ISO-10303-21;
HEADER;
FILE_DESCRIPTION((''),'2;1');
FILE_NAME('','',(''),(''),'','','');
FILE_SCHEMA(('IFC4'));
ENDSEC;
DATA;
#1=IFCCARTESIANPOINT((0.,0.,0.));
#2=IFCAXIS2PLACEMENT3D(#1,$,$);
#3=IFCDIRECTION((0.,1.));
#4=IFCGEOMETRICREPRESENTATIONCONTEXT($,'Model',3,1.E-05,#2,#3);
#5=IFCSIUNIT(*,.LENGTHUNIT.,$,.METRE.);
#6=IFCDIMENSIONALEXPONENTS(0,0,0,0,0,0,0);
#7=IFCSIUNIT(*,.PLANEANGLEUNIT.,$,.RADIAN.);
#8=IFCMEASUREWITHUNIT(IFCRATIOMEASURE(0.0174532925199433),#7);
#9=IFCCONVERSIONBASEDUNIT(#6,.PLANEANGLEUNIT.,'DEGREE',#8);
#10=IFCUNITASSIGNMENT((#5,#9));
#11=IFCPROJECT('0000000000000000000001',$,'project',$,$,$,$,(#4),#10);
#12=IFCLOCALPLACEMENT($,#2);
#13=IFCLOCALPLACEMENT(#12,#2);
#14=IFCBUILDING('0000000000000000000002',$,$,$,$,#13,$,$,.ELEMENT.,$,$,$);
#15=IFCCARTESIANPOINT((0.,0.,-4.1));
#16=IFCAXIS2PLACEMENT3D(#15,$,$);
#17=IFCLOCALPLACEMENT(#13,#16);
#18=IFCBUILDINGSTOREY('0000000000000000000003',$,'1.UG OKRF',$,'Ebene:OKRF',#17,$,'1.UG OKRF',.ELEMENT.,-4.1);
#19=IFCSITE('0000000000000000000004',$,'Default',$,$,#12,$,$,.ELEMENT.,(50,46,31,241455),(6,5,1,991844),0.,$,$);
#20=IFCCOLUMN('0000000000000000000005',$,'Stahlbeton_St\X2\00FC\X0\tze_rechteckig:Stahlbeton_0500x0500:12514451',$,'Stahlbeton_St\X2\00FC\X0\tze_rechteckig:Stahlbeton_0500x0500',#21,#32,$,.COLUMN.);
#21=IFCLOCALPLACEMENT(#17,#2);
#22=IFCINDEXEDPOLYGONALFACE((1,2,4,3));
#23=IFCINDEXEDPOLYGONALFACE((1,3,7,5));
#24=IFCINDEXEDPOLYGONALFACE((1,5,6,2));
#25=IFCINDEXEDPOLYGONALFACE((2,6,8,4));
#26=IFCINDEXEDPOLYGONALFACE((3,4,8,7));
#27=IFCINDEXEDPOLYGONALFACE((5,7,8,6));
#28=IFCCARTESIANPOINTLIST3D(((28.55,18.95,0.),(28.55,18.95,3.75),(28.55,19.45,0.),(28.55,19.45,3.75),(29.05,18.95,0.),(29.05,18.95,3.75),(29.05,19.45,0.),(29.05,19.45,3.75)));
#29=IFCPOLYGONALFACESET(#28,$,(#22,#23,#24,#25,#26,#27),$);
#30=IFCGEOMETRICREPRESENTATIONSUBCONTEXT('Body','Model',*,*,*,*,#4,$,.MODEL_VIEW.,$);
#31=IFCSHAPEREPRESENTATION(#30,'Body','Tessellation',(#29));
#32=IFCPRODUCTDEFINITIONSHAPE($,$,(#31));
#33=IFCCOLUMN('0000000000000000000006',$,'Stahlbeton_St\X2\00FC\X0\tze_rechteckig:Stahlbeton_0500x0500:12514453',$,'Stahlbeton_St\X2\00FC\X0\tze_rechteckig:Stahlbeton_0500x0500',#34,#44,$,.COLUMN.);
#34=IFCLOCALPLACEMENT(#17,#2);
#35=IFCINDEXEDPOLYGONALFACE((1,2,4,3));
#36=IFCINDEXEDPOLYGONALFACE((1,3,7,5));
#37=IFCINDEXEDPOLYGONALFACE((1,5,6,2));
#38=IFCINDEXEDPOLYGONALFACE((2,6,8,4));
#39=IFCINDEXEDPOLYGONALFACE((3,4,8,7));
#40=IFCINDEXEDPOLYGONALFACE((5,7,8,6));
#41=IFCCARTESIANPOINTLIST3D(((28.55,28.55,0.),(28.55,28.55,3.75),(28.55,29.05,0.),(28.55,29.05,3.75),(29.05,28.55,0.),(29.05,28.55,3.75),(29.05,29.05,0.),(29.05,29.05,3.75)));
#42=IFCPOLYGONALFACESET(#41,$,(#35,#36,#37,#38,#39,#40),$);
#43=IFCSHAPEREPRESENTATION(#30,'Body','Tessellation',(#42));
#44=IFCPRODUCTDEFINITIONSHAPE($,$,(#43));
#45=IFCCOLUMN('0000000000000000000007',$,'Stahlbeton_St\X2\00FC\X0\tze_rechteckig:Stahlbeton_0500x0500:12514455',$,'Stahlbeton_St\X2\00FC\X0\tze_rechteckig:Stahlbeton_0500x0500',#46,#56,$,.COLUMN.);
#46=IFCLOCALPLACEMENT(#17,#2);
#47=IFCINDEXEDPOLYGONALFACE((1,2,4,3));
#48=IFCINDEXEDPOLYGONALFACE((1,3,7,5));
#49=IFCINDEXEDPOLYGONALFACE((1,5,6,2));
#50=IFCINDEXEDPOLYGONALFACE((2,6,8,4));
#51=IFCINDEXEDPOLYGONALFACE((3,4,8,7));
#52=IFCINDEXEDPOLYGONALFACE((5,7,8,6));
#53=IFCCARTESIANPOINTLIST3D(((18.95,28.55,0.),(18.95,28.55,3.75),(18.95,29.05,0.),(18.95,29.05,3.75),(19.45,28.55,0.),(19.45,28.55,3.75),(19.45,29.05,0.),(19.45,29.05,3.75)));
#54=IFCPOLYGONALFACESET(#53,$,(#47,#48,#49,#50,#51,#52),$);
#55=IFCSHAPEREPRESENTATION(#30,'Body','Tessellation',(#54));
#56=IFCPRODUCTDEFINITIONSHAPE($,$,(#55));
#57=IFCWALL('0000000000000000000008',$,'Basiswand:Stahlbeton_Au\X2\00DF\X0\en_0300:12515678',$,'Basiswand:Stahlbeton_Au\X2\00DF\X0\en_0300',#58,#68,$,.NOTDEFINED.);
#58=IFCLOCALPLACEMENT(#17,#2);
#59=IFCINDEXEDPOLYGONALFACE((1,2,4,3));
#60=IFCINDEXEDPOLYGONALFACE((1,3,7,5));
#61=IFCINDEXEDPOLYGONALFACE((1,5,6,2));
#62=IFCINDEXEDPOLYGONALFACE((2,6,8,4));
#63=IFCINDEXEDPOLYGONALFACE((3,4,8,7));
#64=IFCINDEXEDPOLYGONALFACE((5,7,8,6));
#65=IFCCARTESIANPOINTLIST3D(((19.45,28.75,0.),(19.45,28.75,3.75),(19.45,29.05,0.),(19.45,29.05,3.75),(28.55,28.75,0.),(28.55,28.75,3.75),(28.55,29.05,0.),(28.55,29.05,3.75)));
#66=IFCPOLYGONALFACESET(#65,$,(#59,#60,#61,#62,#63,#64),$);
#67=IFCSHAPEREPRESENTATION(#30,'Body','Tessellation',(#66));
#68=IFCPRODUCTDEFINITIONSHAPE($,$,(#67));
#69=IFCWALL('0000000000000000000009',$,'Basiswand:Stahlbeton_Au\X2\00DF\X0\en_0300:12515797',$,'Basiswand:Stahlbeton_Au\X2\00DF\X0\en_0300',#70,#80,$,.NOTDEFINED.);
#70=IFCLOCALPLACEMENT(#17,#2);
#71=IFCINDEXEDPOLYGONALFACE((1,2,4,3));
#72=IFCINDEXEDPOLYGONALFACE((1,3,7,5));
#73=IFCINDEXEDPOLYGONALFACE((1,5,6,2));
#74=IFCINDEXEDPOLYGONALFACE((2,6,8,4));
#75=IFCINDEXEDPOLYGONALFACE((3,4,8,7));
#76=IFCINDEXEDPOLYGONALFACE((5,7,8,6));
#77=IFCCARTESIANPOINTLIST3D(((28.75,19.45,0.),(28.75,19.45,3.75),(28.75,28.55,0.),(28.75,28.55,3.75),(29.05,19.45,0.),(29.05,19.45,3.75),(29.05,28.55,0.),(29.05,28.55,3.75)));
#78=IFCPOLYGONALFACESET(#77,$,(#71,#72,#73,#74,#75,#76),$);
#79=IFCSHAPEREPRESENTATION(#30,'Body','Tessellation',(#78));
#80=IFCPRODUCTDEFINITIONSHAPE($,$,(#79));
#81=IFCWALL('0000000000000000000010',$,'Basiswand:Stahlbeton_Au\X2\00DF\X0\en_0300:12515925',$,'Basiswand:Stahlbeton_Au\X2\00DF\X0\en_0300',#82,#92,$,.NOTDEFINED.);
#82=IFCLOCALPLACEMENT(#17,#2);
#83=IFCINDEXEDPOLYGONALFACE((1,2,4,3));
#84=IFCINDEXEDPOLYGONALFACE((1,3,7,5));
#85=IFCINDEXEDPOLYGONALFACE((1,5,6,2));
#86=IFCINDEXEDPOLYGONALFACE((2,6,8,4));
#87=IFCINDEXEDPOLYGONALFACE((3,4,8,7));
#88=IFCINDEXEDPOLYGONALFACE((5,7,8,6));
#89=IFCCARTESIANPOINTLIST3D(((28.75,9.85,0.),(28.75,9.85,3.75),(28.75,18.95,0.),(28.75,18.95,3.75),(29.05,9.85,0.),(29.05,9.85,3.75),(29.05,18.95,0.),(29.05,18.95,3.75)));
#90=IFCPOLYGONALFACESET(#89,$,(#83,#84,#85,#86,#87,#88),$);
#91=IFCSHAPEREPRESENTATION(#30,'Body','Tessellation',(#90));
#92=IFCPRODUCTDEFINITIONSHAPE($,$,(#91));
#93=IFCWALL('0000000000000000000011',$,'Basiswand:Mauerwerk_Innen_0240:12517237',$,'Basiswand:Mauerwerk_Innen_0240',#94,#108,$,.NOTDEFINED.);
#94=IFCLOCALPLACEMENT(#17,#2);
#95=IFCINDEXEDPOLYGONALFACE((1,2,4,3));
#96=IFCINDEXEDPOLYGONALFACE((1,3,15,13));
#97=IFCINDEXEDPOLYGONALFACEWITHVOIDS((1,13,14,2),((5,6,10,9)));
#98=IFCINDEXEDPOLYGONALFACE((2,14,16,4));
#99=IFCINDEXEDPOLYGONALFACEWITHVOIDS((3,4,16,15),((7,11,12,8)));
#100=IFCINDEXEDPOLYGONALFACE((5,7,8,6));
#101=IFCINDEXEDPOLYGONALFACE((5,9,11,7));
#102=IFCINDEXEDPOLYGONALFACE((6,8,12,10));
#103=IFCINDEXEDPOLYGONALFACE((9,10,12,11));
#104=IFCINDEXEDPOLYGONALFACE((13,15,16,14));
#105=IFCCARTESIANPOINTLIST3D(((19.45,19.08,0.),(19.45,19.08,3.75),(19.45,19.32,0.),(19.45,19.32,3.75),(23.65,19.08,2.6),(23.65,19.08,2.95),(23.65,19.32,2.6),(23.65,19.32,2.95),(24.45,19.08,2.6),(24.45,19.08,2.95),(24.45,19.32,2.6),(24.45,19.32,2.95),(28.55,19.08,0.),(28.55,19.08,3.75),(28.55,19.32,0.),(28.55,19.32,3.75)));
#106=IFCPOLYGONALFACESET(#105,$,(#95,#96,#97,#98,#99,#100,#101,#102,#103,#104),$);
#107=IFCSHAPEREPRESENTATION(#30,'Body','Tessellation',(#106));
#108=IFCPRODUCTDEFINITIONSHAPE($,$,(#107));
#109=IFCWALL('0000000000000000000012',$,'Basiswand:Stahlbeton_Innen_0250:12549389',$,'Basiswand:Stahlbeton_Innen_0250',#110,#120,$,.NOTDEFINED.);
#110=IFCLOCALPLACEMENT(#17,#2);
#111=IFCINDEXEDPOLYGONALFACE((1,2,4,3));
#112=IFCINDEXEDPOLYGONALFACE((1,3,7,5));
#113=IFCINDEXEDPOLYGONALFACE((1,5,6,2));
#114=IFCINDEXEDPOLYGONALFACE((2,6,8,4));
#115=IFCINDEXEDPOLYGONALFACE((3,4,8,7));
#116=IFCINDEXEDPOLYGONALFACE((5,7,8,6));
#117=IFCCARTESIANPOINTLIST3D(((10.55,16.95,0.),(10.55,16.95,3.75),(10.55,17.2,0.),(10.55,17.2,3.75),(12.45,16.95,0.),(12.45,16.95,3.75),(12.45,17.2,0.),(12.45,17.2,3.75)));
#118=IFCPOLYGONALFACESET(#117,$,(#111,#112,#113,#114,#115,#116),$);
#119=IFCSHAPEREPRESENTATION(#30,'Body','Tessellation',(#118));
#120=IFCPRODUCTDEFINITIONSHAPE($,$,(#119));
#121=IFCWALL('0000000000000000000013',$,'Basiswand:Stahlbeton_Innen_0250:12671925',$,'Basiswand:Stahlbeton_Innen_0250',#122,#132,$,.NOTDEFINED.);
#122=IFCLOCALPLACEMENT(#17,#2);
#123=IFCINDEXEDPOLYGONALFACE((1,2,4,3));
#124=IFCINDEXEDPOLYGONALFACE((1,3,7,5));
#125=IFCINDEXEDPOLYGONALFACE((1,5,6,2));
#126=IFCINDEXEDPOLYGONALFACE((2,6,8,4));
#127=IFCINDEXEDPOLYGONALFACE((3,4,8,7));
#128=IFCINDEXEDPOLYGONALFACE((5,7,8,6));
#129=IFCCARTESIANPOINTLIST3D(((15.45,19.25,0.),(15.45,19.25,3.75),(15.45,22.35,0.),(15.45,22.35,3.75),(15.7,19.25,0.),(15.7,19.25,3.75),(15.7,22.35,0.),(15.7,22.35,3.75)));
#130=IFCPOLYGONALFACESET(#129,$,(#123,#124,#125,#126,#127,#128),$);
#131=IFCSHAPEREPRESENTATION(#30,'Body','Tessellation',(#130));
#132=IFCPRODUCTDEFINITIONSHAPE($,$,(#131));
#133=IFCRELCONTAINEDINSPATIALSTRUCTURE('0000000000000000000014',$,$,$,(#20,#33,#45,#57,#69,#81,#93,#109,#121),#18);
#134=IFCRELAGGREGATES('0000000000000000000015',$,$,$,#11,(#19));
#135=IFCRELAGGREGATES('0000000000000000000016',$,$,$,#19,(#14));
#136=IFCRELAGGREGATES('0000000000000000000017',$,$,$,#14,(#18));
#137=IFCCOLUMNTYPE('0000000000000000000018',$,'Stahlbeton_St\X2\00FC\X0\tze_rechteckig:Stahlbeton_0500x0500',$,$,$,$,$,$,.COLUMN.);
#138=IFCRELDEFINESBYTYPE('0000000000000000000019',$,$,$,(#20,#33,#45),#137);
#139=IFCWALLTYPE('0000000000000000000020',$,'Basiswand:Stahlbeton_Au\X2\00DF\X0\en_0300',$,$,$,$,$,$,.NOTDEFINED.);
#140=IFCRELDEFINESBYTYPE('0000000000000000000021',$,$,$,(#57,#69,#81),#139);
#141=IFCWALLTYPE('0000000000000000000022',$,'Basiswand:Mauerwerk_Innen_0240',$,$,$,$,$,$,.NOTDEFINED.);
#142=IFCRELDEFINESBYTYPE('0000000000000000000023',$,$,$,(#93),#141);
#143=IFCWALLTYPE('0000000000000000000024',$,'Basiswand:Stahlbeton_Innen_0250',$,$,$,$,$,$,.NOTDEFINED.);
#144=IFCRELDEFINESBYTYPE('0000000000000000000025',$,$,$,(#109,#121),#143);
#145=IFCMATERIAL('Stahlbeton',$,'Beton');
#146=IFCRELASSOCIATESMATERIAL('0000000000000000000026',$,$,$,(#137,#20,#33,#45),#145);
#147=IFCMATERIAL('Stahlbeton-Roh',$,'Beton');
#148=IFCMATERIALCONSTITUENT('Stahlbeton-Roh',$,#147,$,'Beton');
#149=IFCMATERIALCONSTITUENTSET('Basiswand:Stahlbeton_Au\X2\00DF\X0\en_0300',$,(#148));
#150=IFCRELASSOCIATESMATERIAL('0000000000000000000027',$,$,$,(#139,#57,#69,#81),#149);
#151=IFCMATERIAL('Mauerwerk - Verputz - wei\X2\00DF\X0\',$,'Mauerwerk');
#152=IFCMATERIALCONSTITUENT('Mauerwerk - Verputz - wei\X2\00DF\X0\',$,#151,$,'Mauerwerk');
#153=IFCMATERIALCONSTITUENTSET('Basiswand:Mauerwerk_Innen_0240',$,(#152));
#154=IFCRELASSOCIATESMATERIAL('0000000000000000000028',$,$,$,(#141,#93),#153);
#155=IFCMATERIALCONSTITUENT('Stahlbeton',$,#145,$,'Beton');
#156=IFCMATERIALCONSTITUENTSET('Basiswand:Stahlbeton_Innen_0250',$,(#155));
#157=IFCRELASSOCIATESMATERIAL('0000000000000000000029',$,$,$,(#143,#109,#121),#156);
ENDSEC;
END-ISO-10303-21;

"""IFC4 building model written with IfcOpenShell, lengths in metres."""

from ifc_helpers import new_model, entity, si_unit, converted_unit, direction, frame, origin, place, context, subcontext, project, spatial, polyline, indexed_curve, outline, extrude, source, transform, mapped, material, constituent, constituent_set, type_object, type_shapes, element, save


model = new_model("IFC4")

# Units and contexts
model_context = context("Model", 3, precision=1e-05, world=origin(), true_north=direction((0.0, 1.0)))
body_context = subcontext(model_context, "Body", "Model", "MODEL_VIEW")
ifc_project = project(units=[si_unit("LENGTHUNIT", "METRE"), converted_unit("PLANEANGLEUNIT", "DEGREE", entity("IfcRatioMeasure", 0.0174532925199433), si_unit("PLANEANGLEUNIT", "RADIAN"), dimensions=[0, 0, 0, 0, 0, 0, 0])], contexts=[model_context])

# Site, building, storey
site_placement = place(None, origin())
site = spatial("IfcSite", under=ifc_project, at=site_placement, Name="Default", CompositionType="ELEMENT", RefLatitude=(50, 46, 31, 241455), RefLongitude=(6, 5, 1, 991844), RefElevation=0.0)
building_placement = place(site_placement, origin())
building = spatial("IfcBuilding", under=site, at=building_placement, CompositionType="ELEMENT")
storey_placement = place(building_placement, frame((0.0, 0.0, -4.1)))
storey = spatial("IfcBuildingStorey", under=building, at=storey_placement, Name="1.UG OKRF", ObjectType="Ebene:OKRF", LongName="1.UG OKRF", CompositionType="ELEMENT", Elevation=-4.1)

# Columns
ifc_material_1 = material(Name="Stahlbeton", Category="Beton")
column_type = type_object("IfcColumnType", Name="Stahlbeton_Stütze_rechteckig:Stahlbeton_0500x0500", PredefinedType="COLUMN", material=ifc_material_1)
shared_shape = source(origin(), body_context, "Body", "SweptSolid", [
    extrude(outline(indexed_curve([(-0.25, -0.25), (0.25, -0.25), (0.25, 0.25), (-0.25, 0.25), (-0.25, -0.25)], self_intersect=False)), frame((0.0, 0.0, -4.1), z_axis=(0.0, 0.0, 1.0), x_axis=(0.0, -1.0, 0.0)), (0.0, 0.0, 1.0), 3.75),
])
type_shapes(column_type, [shared_shape])
for number, where, name in (
    (1, (28.8, 19.2, 4.1), "Stahlbeton_Stütze_rechteckig:Stahlbeton_0500x0500:12514451"),
    (2, (28.8, 28.8, 4.1), "Stahlbeton_Stütze_rechteckig:Stahlbeton_0500x0500:12514453"),
    (3, (19.2, 28.8, 4.1), "Stahlbeton_Stütze_rechteckig:Stahlbeton_0500x0500:12514455"),
):
    element("IfcColumn", number, at=place(storey_placement, frame(where)), inside=storey, type_object=column_type, material=ifc_material_1, Name=name, ObjectType="Stahlbeton_Stütze_rechteckig:Stahlbeton_0500x0500", PredefinedType="COLUMN", context=body_context, shape_type="MappedRepresentation", body=[
        mapped(shared_shape, transform((0.0, 0.0, 0.0), scale=1.0)),
    ])

# Walls
ifc_material_2 = material(Name="Stahlbeton-Roh", Category="Beton")
ifc_constituent_1 = constituent(ifc_material_2, Name="Stahlbeton-Roh", Category="Beton")
ifc_constituent_set_1 = constituent_set(constituents=[ifc_constituent_1], Name="Basiswand:Stahlbeton_Außen_0300")
wall_type_1 = type_object("IfcWallType", Name="Basiswand:Stahlbeton_Außen_0300", PredefinedType="NOTDEFINED", material=ifc_constituent_set_1)
wall_1_placement = place(storey_placement, frame((19.45, 28.9, 0.0)))
element("IfcWall", 4, at=wall_1_placement, inside=storey, type_object=wall_type_1, material=ifc_constituent_set_1, Name="Basiswand:Stahlbeton_Außen_0300:12515678", ObjectType="Basiswand:Stahlbeton_Außen_0300", PredefinedType="NOTDEFINED", context=body_context, shape_type="SweptSolid", body=[
    extrude(outline(polyline([(-0.15, -4.55), (0.15, -4.55), (0.15, 4.55), (-0.15, 4.55), (-0.15, -4.55)])), frame((4.55, 0.0, 0.0), z_axis=(0.0, 0.0, -1.0), x_axis=(0.0, 1.0, 0.0)), (0.0, 0.0, -1.0), 3.75),
])
for number, where, z_axis, x_axis, name in (
    (5, (28.9, 28.55, 0.0), (0.0, 0.0, 1.0), (0.0, -1.0, 0.0), "Basiswand:Stahlbeton_Außen_0300:12515797"),
    (6, (28.9, 18.95, 0.0), (0.0, 0.0, 1.0), (0.0, -1.0, 0.0), "Basiswand:Stahlbeton_Außen_0300:12515925"),
):
    element("IfcWall", number, at=place(storey_placement, frame(where, z_axis=z_axis, x_axis=x_axis)), inside=storey, type_object=wall_type_1, material=ifc_constituent_set_1, Name=name, ObjectType="Basiswand:Stahlbeton_Außen_0300", PredefinedType="NOTDEFINED", context=body_context, shape_type="SweptSolid", body=[
        extrude(outline(polyline([(-4.55, -0.15), (4.55, -0.15), (4.55, 0.15), (-4.55, 0.15), (-4.55, -0.15)])), frame((4.55, 0.0, 0.0), z_axis=(0.0, 0.0, -1.0), x_axis=(-1.0, 0.0, 0.0)), (0.0, 0.0, -1.0), 3.75),
    ])

# Wall, opening
ifc_material_3 = material(Name="Mauerwerk - Verputz - weiß", Category="Mauerwerk")
ifc_constituent_2 = constituent(ifc_material_3, Name="Mauerwerk - Verputz - weiß", Category="Mauerwerk")
ifc_constituent_set_2 = constituent_set(constituents=[ifc_constituent_2], Name="Basiswand:Mauerwerk_Innen_0240")
wall_type_2 = type_object("IfcWallType", Name="Basiswand:Mauerwerk_Innen_0240", PredefinedType="NOTDEFINED", material=ifc_constituent_set_2)
wall_2_placement = place(storey_placement, frame((19.45, 19.2, 0.0)))
wall_2 = element("IfcWall", 7, at=wall_2_placement, inside=storey, type_object=wall_type_2, material=ifc_constituent_set_2, Name="Basiswand:Mauerwerk_Innen_0240:12517237", ObjectType="Basiswand:Mauerwerk_Innen_0240", PredefinedType="NOTDEFINED", context=body_context, shape_type="SweptSolid", body=[
    extrude(outline(indexed_curve([(-1.875, -4.55), (1.875, -4.55), (1.875, 4.55), (-1.875, 4.55), (-1.875, -4.55)], self_intersect=False), holes=[indexed_curve([(1.075, -0.35), (0.725, -0.35), (0.725, 0.45), (1.075, 0.45), (1.075, -0.35)], self_intersect=False)]), frame((4.55, -0.12, 1.875), z_axis=(0.0, 1.0, 0.0), x_axis=(0.0, 0.0, 1.0)), (0.0, 0.0, 1.0), 0.24),
])
opening_1_placement = place(wall_2_placement, origin())
element("IfcOpeningElement", 8, at=opening_1_placement, cuts=wall_2, ObjectType="Opening", PredefinedType="OPENING", context=body_context, shape_type="SweptSolid", body=[
    extrude(outline(indexed_curve([(-0.175, -0.4), (0.175, -0.4), (0.175, 0.4), (-0.175, 0.4), (-0.175, -0.4)], self_intersect=False)), frame((4.6, -0.12, 2.775), z_axis=(0.0, 1.0, 0.0), x_axis=(0.0, 0.0, -1.0)), (0.0, 0.0, 1.0), 0.24),
])

# Walls
ifc_constituent_3 = constituent(ifc_material_1, Name="Stahlbeton", Category="Beton")
ifc_constituent_set_3 = constituent_set(constituents=[ifc_constituent_3], Name="Basiswand:Stahlbeton_Innen_0250")
wall_type_3 = type_object("IfcWallType", Name="Basiswand:Stahlbeton_Innen_0250", PredefinedType="NOTDEFINED", material=ifc_constituent_set_3)
wall_3_placement = place(storey_placement, frame((12.45, 17.075, 0.0), z_axis=(0.0, 0.0, 1.0), x_axis=(-1.0, 0.0, 0.0)))
element("IfcWall", 9, at=wall_3_placement, inside=storey, type_object=wall_type_3, material=ifc_constituent_set_3, Name="Basiswand:Stahlbeton_Innen_0250:12549389", ObjectType="Basiswand:Stahlbeton_Innen_0250", PredefinedType="NOTDEFINED", context=body_context, shape_type="SweptSolid", body=[
    extrude(outline(indexed_curve([(-0.125, -0.95), (0.125, -0.95), (0.125, 0.95), (-0.125, 0.95), (-0.125, -0.95)], self_intersect=False)), frame((0.95, 0.0, 0.0), z_axis=(0.0, 0.0, 1.0), x_axis=(0.0, 1.0, 0.0)), (0.0, 0.0, 1.0), 3.75),
])
wall_4_placement = place(storey_placement, frame((15.575, 22.35, 0.0), z_axis=(0.0, 0.0, 1.0), x_axis=(0.0, -1.0, 0.0)))
element("IfcWall", 10, at=wall_4_placement, inside=storey, type_object=wall_type_3, material=ifc_constituent_set_3, Name="Basiswand:Stahlbeton_Innen_0250:12671925", ObjectType="Basiswand:Stahlbeton_Innen_0250", PredefinedType="NOTDEFINED", context=body_context, shape_type="SweptSolid", body=[
    extrude(outline(indexed_curve([(-0.125, -1.55), (0.125, -1.55), (0.125, 1.55), (-0.125, 1.55), (-0.125, -1.55)], self_intersect=False)), frame((1.55, 0.0, 0.0), z_axis=(0.0, 0.0, 1.0), x_axis=(0.0, 1.0, 0.0)), (0.0, 0.0, 1.0), 3.75),
])

save(model, "model.ifc")
